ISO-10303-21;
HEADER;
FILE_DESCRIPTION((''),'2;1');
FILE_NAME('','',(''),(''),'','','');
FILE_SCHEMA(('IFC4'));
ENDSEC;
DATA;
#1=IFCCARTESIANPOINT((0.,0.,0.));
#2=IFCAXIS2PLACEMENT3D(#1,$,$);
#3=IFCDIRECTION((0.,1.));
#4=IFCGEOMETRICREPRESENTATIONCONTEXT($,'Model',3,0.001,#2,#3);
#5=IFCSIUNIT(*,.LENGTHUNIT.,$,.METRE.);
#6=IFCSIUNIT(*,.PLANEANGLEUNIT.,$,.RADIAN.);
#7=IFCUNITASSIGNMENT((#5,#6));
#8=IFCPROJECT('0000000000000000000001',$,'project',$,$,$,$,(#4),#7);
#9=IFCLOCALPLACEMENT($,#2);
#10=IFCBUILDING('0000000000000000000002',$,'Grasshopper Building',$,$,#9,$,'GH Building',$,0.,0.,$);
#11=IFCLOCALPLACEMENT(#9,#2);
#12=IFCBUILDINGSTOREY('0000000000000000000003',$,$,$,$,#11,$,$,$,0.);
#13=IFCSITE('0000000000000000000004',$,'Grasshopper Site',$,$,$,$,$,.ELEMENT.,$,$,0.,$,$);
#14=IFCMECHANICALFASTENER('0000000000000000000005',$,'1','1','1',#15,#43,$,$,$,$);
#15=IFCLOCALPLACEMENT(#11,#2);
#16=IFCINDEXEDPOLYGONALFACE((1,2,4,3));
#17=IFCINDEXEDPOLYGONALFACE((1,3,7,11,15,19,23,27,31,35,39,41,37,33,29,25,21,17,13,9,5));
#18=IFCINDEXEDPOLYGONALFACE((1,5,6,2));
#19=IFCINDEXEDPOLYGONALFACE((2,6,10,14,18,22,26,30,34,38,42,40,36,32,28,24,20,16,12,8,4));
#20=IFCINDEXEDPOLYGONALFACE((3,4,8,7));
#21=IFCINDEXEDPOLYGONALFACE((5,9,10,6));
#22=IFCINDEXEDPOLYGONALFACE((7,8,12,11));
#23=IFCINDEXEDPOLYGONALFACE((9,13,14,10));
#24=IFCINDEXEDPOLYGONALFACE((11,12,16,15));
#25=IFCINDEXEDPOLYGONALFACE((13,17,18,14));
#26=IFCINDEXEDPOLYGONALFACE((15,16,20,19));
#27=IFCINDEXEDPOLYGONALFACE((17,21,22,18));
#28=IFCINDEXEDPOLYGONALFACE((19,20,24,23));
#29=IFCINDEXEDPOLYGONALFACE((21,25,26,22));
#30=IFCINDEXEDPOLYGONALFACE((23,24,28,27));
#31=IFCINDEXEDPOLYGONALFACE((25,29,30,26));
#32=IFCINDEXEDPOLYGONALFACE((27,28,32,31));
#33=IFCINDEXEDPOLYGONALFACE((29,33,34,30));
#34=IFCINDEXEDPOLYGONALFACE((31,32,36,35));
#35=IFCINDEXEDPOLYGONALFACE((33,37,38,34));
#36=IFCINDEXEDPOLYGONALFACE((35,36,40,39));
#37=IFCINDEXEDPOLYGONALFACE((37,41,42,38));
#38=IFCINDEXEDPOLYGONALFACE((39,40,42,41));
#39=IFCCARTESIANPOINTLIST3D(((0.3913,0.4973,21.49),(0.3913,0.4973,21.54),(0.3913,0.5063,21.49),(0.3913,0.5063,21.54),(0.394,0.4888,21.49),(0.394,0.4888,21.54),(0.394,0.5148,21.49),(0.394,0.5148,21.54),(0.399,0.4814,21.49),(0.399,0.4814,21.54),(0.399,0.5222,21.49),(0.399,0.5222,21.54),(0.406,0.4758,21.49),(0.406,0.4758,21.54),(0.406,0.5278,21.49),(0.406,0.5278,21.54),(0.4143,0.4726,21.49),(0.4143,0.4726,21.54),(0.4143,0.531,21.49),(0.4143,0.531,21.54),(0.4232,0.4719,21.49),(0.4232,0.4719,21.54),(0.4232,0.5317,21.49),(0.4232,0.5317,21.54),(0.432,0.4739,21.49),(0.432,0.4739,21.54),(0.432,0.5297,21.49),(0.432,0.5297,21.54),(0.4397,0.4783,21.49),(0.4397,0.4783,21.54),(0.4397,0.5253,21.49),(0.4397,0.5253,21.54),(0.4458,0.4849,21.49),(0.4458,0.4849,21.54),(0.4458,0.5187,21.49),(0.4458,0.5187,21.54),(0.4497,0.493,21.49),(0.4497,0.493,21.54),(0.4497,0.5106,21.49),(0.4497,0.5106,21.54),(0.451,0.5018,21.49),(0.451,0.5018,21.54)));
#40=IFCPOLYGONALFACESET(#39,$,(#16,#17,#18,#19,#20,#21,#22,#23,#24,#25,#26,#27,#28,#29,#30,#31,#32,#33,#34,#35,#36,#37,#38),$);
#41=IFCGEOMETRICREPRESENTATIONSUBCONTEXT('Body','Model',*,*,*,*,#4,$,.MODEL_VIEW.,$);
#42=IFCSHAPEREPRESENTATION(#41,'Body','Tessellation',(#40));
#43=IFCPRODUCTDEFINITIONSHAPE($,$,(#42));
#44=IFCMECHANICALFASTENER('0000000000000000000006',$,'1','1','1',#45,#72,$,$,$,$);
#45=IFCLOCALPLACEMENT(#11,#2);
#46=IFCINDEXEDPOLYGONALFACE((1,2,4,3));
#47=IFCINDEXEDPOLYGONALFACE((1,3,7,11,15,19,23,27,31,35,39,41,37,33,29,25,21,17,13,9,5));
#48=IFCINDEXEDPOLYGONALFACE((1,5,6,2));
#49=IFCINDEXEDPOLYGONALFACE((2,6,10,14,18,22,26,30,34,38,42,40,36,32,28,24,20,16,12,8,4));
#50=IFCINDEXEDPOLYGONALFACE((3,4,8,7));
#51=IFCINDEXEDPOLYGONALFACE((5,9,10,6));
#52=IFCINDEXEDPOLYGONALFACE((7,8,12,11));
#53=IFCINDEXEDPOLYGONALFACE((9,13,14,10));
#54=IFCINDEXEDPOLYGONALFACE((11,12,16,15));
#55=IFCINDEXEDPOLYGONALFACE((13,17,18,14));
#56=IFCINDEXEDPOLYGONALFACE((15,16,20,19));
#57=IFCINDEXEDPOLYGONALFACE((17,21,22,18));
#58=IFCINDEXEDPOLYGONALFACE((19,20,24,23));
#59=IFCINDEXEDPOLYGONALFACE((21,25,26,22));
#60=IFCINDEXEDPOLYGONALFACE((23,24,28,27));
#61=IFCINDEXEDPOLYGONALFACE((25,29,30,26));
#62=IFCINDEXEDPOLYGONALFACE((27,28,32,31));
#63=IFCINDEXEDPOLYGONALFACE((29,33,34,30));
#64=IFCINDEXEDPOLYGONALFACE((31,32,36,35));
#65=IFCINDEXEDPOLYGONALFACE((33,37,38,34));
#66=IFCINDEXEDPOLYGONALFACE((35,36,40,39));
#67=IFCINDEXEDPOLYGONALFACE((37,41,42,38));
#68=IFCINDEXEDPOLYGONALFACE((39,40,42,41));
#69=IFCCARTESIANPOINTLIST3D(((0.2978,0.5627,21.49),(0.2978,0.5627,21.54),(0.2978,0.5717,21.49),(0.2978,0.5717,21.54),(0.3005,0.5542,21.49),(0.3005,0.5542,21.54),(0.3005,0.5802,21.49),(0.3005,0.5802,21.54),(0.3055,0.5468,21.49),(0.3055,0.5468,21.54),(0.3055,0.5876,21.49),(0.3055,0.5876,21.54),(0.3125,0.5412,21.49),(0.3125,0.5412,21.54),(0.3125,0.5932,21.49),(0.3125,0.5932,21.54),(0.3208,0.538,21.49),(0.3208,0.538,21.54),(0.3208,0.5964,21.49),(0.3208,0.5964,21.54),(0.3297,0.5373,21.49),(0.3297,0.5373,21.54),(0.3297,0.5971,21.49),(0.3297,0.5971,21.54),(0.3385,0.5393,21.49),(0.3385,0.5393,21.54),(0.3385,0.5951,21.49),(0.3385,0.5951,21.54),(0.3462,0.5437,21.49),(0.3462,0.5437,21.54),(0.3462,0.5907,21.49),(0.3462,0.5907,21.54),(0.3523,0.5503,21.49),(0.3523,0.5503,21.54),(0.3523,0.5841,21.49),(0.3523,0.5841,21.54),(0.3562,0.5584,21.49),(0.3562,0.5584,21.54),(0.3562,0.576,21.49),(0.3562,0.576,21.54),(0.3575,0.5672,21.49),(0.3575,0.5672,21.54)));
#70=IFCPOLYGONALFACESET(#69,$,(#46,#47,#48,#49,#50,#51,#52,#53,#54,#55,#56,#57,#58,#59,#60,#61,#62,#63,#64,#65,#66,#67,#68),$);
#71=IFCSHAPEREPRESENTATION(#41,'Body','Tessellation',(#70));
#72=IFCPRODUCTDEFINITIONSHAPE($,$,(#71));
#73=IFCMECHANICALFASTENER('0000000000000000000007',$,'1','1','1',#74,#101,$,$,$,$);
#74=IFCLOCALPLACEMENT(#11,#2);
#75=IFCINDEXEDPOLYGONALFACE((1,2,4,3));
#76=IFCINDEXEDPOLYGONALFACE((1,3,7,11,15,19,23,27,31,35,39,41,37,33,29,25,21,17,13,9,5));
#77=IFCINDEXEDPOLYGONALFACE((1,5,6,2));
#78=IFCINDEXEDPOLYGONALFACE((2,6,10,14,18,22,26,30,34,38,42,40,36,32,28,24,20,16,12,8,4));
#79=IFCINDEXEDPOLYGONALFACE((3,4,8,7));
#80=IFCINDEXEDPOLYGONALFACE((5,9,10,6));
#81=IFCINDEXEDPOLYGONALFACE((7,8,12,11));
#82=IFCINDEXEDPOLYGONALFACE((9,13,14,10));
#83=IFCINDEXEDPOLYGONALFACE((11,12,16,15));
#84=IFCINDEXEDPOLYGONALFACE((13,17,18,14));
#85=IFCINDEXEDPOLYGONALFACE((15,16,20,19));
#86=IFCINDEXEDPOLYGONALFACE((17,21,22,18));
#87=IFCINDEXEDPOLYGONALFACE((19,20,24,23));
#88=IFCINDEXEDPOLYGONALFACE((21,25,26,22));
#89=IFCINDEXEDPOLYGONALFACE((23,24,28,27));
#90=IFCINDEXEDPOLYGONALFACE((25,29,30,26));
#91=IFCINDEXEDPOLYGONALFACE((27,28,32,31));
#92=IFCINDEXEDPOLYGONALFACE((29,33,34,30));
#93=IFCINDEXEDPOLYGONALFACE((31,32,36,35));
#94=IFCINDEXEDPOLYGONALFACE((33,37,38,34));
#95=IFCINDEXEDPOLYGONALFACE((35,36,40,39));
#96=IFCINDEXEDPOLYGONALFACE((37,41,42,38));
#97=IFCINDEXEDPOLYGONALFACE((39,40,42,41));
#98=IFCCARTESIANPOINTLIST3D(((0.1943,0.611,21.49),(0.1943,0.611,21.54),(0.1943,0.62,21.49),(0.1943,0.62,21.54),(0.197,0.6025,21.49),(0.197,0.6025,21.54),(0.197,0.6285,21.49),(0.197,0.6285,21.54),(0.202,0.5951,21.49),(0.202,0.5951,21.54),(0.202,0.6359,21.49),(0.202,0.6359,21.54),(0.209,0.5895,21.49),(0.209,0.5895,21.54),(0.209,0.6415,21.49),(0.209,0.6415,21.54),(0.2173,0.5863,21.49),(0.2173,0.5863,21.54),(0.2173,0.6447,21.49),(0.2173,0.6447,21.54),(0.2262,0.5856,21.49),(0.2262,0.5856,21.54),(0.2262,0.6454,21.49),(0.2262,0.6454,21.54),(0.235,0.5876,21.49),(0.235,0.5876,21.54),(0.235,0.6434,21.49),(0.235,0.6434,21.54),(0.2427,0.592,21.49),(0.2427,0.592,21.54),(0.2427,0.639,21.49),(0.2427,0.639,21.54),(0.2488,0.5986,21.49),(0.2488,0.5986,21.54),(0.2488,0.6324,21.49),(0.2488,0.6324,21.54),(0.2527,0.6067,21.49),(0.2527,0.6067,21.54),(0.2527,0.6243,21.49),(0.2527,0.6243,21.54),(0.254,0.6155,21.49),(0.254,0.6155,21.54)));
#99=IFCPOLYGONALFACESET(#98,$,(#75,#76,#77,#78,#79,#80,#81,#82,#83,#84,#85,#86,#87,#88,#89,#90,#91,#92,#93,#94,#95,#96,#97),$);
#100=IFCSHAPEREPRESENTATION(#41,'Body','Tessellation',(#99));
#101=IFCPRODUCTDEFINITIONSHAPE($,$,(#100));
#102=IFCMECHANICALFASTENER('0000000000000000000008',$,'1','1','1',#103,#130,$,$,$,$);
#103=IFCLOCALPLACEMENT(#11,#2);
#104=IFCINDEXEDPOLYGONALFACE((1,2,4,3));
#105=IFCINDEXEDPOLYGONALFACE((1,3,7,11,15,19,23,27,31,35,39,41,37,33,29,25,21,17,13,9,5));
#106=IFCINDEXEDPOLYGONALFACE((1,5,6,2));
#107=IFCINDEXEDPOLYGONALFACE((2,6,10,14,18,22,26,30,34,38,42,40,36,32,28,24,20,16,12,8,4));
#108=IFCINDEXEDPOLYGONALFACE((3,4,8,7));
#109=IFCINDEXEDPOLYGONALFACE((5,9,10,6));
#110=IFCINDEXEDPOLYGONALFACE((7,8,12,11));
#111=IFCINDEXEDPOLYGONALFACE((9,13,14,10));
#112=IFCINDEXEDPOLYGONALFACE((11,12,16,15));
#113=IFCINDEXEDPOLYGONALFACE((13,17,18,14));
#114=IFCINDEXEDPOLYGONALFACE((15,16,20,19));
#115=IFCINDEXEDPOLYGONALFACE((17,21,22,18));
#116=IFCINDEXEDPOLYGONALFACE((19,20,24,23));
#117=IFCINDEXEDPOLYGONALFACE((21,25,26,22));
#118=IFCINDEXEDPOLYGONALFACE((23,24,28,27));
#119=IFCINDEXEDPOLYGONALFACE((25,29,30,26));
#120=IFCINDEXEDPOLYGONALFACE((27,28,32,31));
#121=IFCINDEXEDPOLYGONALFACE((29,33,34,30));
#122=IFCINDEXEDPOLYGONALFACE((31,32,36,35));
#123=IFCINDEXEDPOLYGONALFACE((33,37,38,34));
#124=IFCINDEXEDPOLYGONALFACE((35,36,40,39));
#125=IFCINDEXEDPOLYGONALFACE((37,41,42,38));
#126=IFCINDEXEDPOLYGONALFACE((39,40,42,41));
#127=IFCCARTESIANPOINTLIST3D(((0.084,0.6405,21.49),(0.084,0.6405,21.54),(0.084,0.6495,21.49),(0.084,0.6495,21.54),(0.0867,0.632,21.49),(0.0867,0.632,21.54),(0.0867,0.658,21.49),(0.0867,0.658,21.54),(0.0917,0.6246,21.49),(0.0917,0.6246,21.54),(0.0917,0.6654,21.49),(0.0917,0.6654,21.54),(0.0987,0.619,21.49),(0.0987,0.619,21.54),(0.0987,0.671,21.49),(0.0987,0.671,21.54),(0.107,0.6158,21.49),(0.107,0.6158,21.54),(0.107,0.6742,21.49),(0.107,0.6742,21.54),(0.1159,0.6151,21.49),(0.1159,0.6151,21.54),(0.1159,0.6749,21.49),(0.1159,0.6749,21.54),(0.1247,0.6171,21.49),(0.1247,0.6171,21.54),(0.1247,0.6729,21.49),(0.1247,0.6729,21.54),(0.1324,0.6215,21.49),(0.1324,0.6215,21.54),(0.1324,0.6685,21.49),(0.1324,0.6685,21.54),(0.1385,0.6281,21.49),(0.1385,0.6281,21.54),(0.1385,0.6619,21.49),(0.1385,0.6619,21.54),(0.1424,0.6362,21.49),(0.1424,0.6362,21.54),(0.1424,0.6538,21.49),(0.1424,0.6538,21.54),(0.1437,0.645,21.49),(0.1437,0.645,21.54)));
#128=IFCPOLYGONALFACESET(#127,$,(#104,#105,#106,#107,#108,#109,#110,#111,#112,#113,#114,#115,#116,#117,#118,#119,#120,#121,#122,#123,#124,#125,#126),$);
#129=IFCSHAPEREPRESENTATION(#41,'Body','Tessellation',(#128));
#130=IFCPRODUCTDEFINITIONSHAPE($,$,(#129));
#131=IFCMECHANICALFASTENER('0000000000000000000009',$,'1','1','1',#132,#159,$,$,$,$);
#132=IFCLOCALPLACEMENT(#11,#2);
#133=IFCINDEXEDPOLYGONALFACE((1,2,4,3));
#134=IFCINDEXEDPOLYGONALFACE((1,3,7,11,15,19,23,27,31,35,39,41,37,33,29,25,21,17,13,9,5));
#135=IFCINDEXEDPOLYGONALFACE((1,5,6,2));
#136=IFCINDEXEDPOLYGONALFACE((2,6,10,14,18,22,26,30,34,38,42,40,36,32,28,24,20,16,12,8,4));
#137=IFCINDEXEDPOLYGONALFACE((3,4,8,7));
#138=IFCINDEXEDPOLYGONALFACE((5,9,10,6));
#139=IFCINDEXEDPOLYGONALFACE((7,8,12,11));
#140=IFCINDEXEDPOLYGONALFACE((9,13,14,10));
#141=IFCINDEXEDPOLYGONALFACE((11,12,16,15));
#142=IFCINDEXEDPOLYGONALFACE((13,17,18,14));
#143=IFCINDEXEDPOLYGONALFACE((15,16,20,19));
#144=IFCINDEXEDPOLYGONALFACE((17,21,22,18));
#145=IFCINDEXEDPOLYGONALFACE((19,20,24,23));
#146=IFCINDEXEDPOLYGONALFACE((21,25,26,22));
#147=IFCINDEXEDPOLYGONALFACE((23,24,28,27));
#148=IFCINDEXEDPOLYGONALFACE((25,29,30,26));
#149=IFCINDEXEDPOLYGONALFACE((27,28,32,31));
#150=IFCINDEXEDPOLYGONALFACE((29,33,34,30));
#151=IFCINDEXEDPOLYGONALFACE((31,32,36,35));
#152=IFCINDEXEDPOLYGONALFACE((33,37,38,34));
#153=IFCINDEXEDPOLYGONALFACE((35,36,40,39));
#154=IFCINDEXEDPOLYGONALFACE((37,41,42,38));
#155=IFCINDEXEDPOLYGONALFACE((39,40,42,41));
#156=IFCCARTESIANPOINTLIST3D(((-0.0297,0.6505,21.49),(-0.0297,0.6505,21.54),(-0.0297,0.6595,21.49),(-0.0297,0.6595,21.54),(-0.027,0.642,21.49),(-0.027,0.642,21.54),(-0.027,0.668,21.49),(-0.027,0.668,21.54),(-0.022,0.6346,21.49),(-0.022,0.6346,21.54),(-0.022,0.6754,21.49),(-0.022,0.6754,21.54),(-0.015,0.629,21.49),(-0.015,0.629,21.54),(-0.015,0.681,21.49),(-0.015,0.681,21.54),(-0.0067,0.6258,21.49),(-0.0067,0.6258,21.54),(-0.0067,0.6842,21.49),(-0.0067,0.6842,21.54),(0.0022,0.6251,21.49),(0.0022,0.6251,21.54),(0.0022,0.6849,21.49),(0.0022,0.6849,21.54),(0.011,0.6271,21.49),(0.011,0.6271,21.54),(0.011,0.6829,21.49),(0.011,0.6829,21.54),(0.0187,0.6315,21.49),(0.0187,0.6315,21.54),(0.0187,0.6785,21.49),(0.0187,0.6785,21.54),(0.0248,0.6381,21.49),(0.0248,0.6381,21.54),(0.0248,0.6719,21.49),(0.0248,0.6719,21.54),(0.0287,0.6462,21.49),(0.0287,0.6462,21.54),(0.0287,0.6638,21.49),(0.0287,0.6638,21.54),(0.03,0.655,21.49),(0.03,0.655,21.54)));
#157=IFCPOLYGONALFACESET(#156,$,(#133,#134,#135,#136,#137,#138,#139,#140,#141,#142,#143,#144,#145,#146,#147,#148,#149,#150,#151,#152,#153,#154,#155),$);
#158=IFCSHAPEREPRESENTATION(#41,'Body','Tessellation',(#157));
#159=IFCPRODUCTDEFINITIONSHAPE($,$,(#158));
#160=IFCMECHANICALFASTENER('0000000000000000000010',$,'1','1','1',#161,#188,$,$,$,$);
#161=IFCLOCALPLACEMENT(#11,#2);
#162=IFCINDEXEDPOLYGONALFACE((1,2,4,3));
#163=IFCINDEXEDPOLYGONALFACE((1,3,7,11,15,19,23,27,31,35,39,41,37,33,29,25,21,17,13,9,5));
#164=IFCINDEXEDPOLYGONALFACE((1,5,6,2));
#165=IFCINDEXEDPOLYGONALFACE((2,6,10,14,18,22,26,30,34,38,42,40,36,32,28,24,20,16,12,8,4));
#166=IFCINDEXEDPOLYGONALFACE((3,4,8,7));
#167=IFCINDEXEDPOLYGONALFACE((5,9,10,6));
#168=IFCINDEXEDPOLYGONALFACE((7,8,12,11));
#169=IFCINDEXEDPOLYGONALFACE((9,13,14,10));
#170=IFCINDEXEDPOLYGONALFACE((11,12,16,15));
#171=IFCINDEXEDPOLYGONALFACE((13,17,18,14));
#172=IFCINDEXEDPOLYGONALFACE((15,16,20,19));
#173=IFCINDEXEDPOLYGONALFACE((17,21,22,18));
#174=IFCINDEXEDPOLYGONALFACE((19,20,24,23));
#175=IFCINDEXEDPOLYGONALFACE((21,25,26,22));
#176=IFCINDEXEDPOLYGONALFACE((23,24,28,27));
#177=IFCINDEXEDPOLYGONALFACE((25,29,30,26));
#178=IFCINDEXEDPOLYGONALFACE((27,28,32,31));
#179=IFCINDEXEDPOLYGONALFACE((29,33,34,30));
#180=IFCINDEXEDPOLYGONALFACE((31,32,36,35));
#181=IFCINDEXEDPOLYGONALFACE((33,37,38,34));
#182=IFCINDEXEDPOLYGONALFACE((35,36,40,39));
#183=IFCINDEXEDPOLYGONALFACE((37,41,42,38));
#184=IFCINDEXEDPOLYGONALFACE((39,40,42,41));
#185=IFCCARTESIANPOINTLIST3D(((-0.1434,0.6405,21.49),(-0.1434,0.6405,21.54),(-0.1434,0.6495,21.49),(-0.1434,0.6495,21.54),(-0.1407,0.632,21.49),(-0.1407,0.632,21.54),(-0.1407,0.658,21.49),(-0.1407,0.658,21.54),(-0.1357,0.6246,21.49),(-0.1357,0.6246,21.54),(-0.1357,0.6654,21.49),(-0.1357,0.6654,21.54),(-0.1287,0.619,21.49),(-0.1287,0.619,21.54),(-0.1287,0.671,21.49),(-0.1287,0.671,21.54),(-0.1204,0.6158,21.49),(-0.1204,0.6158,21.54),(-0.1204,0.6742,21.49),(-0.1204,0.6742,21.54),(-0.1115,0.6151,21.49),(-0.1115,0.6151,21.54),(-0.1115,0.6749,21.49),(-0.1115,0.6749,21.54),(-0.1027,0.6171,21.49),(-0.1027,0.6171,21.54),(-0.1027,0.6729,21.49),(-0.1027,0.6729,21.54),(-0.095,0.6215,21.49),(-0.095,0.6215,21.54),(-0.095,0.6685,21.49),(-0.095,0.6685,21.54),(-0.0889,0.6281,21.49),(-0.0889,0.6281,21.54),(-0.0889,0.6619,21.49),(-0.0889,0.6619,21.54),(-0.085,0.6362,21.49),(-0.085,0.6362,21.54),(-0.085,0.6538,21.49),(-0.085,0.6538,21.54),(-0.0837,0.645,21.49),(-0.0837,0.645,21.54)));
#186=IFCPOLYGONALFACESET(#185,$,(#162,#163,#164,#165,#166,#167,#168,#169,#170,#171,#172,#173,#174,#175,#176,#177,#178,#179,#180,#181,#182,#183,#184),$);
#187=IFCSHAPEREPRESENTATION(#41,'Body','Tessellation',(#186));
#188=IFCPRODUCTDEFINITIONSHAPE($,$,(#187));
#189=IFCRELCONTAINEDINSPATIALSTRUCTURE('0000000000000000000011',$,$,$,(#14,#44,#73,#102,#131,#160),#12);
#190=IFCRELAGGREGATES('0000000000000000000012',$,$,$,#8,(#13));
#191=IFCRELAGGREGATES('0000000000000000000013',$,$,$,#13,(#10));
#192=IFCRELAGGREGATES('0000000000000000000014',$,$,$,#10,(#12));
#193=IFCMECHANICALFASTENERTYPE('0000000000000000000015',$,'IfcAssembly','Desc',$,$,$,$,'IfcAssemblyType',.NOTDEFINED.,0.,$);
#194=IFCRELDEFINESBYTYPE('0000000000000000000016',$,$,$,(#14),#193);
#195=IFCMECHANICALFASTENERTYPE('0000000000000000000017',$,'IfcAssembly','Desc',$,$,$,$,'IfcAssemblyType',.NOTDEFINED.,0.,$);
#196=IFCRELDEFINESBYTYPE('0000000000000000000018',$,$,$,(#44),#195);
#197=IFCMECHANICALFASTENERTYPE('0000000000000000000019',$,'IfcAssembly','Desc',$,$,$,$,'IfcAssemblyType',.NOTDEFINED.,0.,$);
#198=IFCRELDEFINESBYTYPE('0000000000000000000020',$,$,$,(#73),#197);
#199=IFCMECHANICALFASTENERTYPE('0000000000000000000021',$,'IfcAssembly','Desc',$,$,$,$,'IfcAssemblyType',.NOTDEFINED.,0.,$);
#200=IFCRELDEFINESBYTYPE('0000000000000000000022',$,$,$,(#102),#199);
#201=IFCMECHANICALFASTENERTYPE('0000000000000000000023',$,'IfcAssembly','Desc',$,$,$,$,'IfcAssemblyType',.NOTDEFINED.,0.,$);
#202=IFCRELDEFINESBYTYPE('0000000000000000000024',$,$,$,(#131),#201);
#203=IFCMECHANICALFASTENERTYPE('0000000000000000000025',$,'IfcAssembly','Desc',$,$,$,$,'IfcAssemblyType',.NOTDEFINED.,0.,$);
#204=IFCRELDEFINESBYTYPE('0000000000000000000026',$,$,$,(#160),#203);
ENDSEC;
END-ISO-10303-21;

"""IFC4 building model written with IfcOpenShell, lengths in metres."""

from ifc_helpers import new_model, si_unit, direction, frame, origin, place, context, subcontext, project, spatial, circle, extrude, source, transform, mapped, type_object, type_shapes, element, save


model = new_model("IFC4")

# Units and contexts
model_context = context("Model", 3, precision=0.001, world=origin(), true_north=direction((0.0, 1.0)))
body_context = subcontext(model_context, "Body", "Model", "MODEL_VIEW")
ifc_project = project(units=[si_unit("LENGTHUNIT", "METRE"), si_unit("PLANEANGLEUNIT", "RADIAN")], contexts=[model_context])

# Site, building, storey
site = spatial("IfcSite", under=ifc_project, Name="Grasshopper Site", CompositionType="ELEMENT", RefElevation=0.0)
building_placement = place(None, origin())
building = spatial("IfcBuilding", under=site, at=building_placement, Name="Grasshopper Building", LongName="GH Building", ElevationOfRefHeight=0.0, ElevationOfTerrain=0.0)
storey_placement = place(building_placement, origin())
storey = spatial("IfcBuildingStorey", under=building, at=storey_placement, Elevation=0.0)

# Mechanical fasteners
mechanical_fastener_type_1 = type_object("IfcMechanicalFastenerType", Name="IfcAssembly", Description="Desc", ElementType="IfcAssemblyType", NominalDiameter=0.0)
shared_shape_1 = source(origin(), body_context, "Body", "SweptSolid", [
    extrude(circle(Radius=0.03), frame((0.421, 0.5018, 21.54), z_axis=(0.0, 0.0, -1.0), x_axis=(1.0, 0.0, 0.0)), (0.0, 0.0, 1.0), 0.05),
])
type_shapes(mechanical_fastener_type_1, [shared_shape_1])
mechanical_fastener_1_placement = place(storey_placement, origin())
element("IfcMechanicalFastener", 1, at=mechanical_fastener_1_placement, inside=storey, type_object=mechanical_fastener_type_1, Name="1", Description="1", ObjectType="1", context=body_context, shape_type="MappedRepresentation", body=[
    mapped(shared_shape_1, transform((0.0, 0.0, 0.0), scale=1.0)),
])
mechanical_fastener_type_2 = type_object("IfcMechanicalFastenerType", Name="IfcAssembly", Description="Desc", ElementType="IfcAssemblyType", NominalDiameter=0.0)
shared_shape_2 = source(origin(), body_context, "Body", "SweptSolid", [
    extrude(circle(Radius=0.03), frame((0.3275, 0.5672, 21.54), z_axis=(0.0, 0.0, -1.0), x_axis=(1.0, 0.0, 0.0)), (0.0, 0.0, 1.0), 0.05),
])
type_shapes(mechanical_fastener_type_2, [shared_shape_2])
mechanical_fastener_2_placement = place(storey_placement, origin())
element("IfcMechanicalFastener", 2, at=mechanical_fastener_2_placement, inside=storey, type_object=mechanical_fastener_type_2, Name="1", Description="1", ObjectType="1", context=body_context, shape_type="MappedRepresentation", body=[
    mapped(shared_shape_2, transform((0.0, 0.0, 0.0), scale=1.0)),
])
mechanical_fastener_type_3 = type_object("IfcMechanicalFastenerType", Name="IfcAssembly", Description="Desc", ElementType="IfcAssemblyType", NominalDiameter=0.0)
shared_shape_3 = source(origin(), body_context, "Body", "SweptSolid", [
    extrude(circle(Radius=0.03), frame((0.224, 0.6155, 21.54), z_axis=(0.0, 0.0, -1.0), x_axis=(1.0, 0.0, 0.0)), (0.0, 0.0, 1.0), 0.05),
])
type_shapes(mechanical_fastener_type_3, [shared_shape_3])
mechanical_fastener_3_placement = place(storey_placement, origin())
element("IfcMechanicalFastener", 3, at=mechanical_fastener_3_placement, inside=storey, type_object=mechanical_fastener_type_3, Name="1", Description="1", ObjectType="1", context=body_context, shape_type="MappedRepresentation", body=[
    mapped(shared_shape_3, transform((0.0, 0.0, 0.0), scale=1.0)),
])
mechanical_fastener_type_4 = type_object("IfcMechanicalFastenerType", Name="IfcAssembly", Description="Desc", ElementType="IfcAssemblyType", NominalDiameter=0.0)
shared_shape_4 = source(origin(), body_context, "Body", "SweptSolid", [
    extrude(circle(Radius=0.03), frame((0.1137, 0.645, 21.54), z_axis=(0.0, 0.0, -1.0), x_axis=(1.0, 0.0, 0.0)), (0.0, 0.0, 1.0), 0.05),
])
type_shapes(mechanical_fastener_type_4, [shared_shape_4])
mechanical_fastener_4_placement = place(storey_placement, origin())
element("IfcMechanicalFastener", 4, at=mechanical_fastener_4_placement, inside=storey, type_object=mechanical_fastener_type_4, Name="1", Description="1", ObjectType="1", context=body_context, shape_type="MappedRepresentation", body=[
    mapped(shared_shape_4, transform((0.0, 0.0, 0.0), scale=1.0)),
])
mechanical_fastener_type_5 = type_object("IfcMechanicalFastenerType", Name="IfcAssembly", Description="Desc", ElementType="IfcAssemblyType", NominalDiameter=0.0)
shared_shape_5 = source(origin(), body_context, "Body", "SweptSolid", [
    extrude(circle(Radius=0.03), frame((0.0, 0.655, 21.54), z_axis=(0.0, 0.0, -1.0), x_axis=(1.0, 0.0, 0.0)), (0.0, 0.0, 1.0), 0.05),
])
type_shapes(mechanical_fastener_type_5, [shared_shape_5])
mechanical_fastener_5_placement = place(storey_placement, origin())
element("IfcMechanicalFastener", 5, at=mechanical_fastener_5_placement, inside=storey, type_object=mechanical_fastener_type_5, Name="1", Description="1", ObjectType="1", context=body_context, shape_type="MappedRepresentation", body=[
    mapped(shared_shape_5, transform((0.0, 0.0, 0.0), scale=1.0)),
])
mechanical_fastener_type_6 = type_object("IfcMechanicalFastenerType", Name="IfcAssembly", Description="Desc", ElementType="IfcAssemblyType", NominalDiameter=0.0)
shared_shape_6 = source(origin(), body_context, "Body", "SweptSolid", [
    extrude(circle(Radius=0.03), frame((-0.1137, 0.645, 21.54), z_axis=(0.0, 0.0, -1.0), x_axis=(1.0, 0.0, 0.0)), (0.0, 0.0, 1.0), 0.05),
])
type_shapes(mechanical_fastener_type_6, [shared_shape_6])
mechanical_fastener_6_placement = place(storey_placement, origin())
element("IfcMechanicalFastener", 6, at=mechanical_fastener_6_placement, inside=storey, type_object=mechanical_fastener_type_6, Name="1", Description="1", ObjectType="1", context=body_context, shape_type="MappedRepresentation", body=[
    mapped(shared_shape_6, transform((0.0, 0.0, 0.0), scale=1.0)),
])

save(model, "model.ifc")
